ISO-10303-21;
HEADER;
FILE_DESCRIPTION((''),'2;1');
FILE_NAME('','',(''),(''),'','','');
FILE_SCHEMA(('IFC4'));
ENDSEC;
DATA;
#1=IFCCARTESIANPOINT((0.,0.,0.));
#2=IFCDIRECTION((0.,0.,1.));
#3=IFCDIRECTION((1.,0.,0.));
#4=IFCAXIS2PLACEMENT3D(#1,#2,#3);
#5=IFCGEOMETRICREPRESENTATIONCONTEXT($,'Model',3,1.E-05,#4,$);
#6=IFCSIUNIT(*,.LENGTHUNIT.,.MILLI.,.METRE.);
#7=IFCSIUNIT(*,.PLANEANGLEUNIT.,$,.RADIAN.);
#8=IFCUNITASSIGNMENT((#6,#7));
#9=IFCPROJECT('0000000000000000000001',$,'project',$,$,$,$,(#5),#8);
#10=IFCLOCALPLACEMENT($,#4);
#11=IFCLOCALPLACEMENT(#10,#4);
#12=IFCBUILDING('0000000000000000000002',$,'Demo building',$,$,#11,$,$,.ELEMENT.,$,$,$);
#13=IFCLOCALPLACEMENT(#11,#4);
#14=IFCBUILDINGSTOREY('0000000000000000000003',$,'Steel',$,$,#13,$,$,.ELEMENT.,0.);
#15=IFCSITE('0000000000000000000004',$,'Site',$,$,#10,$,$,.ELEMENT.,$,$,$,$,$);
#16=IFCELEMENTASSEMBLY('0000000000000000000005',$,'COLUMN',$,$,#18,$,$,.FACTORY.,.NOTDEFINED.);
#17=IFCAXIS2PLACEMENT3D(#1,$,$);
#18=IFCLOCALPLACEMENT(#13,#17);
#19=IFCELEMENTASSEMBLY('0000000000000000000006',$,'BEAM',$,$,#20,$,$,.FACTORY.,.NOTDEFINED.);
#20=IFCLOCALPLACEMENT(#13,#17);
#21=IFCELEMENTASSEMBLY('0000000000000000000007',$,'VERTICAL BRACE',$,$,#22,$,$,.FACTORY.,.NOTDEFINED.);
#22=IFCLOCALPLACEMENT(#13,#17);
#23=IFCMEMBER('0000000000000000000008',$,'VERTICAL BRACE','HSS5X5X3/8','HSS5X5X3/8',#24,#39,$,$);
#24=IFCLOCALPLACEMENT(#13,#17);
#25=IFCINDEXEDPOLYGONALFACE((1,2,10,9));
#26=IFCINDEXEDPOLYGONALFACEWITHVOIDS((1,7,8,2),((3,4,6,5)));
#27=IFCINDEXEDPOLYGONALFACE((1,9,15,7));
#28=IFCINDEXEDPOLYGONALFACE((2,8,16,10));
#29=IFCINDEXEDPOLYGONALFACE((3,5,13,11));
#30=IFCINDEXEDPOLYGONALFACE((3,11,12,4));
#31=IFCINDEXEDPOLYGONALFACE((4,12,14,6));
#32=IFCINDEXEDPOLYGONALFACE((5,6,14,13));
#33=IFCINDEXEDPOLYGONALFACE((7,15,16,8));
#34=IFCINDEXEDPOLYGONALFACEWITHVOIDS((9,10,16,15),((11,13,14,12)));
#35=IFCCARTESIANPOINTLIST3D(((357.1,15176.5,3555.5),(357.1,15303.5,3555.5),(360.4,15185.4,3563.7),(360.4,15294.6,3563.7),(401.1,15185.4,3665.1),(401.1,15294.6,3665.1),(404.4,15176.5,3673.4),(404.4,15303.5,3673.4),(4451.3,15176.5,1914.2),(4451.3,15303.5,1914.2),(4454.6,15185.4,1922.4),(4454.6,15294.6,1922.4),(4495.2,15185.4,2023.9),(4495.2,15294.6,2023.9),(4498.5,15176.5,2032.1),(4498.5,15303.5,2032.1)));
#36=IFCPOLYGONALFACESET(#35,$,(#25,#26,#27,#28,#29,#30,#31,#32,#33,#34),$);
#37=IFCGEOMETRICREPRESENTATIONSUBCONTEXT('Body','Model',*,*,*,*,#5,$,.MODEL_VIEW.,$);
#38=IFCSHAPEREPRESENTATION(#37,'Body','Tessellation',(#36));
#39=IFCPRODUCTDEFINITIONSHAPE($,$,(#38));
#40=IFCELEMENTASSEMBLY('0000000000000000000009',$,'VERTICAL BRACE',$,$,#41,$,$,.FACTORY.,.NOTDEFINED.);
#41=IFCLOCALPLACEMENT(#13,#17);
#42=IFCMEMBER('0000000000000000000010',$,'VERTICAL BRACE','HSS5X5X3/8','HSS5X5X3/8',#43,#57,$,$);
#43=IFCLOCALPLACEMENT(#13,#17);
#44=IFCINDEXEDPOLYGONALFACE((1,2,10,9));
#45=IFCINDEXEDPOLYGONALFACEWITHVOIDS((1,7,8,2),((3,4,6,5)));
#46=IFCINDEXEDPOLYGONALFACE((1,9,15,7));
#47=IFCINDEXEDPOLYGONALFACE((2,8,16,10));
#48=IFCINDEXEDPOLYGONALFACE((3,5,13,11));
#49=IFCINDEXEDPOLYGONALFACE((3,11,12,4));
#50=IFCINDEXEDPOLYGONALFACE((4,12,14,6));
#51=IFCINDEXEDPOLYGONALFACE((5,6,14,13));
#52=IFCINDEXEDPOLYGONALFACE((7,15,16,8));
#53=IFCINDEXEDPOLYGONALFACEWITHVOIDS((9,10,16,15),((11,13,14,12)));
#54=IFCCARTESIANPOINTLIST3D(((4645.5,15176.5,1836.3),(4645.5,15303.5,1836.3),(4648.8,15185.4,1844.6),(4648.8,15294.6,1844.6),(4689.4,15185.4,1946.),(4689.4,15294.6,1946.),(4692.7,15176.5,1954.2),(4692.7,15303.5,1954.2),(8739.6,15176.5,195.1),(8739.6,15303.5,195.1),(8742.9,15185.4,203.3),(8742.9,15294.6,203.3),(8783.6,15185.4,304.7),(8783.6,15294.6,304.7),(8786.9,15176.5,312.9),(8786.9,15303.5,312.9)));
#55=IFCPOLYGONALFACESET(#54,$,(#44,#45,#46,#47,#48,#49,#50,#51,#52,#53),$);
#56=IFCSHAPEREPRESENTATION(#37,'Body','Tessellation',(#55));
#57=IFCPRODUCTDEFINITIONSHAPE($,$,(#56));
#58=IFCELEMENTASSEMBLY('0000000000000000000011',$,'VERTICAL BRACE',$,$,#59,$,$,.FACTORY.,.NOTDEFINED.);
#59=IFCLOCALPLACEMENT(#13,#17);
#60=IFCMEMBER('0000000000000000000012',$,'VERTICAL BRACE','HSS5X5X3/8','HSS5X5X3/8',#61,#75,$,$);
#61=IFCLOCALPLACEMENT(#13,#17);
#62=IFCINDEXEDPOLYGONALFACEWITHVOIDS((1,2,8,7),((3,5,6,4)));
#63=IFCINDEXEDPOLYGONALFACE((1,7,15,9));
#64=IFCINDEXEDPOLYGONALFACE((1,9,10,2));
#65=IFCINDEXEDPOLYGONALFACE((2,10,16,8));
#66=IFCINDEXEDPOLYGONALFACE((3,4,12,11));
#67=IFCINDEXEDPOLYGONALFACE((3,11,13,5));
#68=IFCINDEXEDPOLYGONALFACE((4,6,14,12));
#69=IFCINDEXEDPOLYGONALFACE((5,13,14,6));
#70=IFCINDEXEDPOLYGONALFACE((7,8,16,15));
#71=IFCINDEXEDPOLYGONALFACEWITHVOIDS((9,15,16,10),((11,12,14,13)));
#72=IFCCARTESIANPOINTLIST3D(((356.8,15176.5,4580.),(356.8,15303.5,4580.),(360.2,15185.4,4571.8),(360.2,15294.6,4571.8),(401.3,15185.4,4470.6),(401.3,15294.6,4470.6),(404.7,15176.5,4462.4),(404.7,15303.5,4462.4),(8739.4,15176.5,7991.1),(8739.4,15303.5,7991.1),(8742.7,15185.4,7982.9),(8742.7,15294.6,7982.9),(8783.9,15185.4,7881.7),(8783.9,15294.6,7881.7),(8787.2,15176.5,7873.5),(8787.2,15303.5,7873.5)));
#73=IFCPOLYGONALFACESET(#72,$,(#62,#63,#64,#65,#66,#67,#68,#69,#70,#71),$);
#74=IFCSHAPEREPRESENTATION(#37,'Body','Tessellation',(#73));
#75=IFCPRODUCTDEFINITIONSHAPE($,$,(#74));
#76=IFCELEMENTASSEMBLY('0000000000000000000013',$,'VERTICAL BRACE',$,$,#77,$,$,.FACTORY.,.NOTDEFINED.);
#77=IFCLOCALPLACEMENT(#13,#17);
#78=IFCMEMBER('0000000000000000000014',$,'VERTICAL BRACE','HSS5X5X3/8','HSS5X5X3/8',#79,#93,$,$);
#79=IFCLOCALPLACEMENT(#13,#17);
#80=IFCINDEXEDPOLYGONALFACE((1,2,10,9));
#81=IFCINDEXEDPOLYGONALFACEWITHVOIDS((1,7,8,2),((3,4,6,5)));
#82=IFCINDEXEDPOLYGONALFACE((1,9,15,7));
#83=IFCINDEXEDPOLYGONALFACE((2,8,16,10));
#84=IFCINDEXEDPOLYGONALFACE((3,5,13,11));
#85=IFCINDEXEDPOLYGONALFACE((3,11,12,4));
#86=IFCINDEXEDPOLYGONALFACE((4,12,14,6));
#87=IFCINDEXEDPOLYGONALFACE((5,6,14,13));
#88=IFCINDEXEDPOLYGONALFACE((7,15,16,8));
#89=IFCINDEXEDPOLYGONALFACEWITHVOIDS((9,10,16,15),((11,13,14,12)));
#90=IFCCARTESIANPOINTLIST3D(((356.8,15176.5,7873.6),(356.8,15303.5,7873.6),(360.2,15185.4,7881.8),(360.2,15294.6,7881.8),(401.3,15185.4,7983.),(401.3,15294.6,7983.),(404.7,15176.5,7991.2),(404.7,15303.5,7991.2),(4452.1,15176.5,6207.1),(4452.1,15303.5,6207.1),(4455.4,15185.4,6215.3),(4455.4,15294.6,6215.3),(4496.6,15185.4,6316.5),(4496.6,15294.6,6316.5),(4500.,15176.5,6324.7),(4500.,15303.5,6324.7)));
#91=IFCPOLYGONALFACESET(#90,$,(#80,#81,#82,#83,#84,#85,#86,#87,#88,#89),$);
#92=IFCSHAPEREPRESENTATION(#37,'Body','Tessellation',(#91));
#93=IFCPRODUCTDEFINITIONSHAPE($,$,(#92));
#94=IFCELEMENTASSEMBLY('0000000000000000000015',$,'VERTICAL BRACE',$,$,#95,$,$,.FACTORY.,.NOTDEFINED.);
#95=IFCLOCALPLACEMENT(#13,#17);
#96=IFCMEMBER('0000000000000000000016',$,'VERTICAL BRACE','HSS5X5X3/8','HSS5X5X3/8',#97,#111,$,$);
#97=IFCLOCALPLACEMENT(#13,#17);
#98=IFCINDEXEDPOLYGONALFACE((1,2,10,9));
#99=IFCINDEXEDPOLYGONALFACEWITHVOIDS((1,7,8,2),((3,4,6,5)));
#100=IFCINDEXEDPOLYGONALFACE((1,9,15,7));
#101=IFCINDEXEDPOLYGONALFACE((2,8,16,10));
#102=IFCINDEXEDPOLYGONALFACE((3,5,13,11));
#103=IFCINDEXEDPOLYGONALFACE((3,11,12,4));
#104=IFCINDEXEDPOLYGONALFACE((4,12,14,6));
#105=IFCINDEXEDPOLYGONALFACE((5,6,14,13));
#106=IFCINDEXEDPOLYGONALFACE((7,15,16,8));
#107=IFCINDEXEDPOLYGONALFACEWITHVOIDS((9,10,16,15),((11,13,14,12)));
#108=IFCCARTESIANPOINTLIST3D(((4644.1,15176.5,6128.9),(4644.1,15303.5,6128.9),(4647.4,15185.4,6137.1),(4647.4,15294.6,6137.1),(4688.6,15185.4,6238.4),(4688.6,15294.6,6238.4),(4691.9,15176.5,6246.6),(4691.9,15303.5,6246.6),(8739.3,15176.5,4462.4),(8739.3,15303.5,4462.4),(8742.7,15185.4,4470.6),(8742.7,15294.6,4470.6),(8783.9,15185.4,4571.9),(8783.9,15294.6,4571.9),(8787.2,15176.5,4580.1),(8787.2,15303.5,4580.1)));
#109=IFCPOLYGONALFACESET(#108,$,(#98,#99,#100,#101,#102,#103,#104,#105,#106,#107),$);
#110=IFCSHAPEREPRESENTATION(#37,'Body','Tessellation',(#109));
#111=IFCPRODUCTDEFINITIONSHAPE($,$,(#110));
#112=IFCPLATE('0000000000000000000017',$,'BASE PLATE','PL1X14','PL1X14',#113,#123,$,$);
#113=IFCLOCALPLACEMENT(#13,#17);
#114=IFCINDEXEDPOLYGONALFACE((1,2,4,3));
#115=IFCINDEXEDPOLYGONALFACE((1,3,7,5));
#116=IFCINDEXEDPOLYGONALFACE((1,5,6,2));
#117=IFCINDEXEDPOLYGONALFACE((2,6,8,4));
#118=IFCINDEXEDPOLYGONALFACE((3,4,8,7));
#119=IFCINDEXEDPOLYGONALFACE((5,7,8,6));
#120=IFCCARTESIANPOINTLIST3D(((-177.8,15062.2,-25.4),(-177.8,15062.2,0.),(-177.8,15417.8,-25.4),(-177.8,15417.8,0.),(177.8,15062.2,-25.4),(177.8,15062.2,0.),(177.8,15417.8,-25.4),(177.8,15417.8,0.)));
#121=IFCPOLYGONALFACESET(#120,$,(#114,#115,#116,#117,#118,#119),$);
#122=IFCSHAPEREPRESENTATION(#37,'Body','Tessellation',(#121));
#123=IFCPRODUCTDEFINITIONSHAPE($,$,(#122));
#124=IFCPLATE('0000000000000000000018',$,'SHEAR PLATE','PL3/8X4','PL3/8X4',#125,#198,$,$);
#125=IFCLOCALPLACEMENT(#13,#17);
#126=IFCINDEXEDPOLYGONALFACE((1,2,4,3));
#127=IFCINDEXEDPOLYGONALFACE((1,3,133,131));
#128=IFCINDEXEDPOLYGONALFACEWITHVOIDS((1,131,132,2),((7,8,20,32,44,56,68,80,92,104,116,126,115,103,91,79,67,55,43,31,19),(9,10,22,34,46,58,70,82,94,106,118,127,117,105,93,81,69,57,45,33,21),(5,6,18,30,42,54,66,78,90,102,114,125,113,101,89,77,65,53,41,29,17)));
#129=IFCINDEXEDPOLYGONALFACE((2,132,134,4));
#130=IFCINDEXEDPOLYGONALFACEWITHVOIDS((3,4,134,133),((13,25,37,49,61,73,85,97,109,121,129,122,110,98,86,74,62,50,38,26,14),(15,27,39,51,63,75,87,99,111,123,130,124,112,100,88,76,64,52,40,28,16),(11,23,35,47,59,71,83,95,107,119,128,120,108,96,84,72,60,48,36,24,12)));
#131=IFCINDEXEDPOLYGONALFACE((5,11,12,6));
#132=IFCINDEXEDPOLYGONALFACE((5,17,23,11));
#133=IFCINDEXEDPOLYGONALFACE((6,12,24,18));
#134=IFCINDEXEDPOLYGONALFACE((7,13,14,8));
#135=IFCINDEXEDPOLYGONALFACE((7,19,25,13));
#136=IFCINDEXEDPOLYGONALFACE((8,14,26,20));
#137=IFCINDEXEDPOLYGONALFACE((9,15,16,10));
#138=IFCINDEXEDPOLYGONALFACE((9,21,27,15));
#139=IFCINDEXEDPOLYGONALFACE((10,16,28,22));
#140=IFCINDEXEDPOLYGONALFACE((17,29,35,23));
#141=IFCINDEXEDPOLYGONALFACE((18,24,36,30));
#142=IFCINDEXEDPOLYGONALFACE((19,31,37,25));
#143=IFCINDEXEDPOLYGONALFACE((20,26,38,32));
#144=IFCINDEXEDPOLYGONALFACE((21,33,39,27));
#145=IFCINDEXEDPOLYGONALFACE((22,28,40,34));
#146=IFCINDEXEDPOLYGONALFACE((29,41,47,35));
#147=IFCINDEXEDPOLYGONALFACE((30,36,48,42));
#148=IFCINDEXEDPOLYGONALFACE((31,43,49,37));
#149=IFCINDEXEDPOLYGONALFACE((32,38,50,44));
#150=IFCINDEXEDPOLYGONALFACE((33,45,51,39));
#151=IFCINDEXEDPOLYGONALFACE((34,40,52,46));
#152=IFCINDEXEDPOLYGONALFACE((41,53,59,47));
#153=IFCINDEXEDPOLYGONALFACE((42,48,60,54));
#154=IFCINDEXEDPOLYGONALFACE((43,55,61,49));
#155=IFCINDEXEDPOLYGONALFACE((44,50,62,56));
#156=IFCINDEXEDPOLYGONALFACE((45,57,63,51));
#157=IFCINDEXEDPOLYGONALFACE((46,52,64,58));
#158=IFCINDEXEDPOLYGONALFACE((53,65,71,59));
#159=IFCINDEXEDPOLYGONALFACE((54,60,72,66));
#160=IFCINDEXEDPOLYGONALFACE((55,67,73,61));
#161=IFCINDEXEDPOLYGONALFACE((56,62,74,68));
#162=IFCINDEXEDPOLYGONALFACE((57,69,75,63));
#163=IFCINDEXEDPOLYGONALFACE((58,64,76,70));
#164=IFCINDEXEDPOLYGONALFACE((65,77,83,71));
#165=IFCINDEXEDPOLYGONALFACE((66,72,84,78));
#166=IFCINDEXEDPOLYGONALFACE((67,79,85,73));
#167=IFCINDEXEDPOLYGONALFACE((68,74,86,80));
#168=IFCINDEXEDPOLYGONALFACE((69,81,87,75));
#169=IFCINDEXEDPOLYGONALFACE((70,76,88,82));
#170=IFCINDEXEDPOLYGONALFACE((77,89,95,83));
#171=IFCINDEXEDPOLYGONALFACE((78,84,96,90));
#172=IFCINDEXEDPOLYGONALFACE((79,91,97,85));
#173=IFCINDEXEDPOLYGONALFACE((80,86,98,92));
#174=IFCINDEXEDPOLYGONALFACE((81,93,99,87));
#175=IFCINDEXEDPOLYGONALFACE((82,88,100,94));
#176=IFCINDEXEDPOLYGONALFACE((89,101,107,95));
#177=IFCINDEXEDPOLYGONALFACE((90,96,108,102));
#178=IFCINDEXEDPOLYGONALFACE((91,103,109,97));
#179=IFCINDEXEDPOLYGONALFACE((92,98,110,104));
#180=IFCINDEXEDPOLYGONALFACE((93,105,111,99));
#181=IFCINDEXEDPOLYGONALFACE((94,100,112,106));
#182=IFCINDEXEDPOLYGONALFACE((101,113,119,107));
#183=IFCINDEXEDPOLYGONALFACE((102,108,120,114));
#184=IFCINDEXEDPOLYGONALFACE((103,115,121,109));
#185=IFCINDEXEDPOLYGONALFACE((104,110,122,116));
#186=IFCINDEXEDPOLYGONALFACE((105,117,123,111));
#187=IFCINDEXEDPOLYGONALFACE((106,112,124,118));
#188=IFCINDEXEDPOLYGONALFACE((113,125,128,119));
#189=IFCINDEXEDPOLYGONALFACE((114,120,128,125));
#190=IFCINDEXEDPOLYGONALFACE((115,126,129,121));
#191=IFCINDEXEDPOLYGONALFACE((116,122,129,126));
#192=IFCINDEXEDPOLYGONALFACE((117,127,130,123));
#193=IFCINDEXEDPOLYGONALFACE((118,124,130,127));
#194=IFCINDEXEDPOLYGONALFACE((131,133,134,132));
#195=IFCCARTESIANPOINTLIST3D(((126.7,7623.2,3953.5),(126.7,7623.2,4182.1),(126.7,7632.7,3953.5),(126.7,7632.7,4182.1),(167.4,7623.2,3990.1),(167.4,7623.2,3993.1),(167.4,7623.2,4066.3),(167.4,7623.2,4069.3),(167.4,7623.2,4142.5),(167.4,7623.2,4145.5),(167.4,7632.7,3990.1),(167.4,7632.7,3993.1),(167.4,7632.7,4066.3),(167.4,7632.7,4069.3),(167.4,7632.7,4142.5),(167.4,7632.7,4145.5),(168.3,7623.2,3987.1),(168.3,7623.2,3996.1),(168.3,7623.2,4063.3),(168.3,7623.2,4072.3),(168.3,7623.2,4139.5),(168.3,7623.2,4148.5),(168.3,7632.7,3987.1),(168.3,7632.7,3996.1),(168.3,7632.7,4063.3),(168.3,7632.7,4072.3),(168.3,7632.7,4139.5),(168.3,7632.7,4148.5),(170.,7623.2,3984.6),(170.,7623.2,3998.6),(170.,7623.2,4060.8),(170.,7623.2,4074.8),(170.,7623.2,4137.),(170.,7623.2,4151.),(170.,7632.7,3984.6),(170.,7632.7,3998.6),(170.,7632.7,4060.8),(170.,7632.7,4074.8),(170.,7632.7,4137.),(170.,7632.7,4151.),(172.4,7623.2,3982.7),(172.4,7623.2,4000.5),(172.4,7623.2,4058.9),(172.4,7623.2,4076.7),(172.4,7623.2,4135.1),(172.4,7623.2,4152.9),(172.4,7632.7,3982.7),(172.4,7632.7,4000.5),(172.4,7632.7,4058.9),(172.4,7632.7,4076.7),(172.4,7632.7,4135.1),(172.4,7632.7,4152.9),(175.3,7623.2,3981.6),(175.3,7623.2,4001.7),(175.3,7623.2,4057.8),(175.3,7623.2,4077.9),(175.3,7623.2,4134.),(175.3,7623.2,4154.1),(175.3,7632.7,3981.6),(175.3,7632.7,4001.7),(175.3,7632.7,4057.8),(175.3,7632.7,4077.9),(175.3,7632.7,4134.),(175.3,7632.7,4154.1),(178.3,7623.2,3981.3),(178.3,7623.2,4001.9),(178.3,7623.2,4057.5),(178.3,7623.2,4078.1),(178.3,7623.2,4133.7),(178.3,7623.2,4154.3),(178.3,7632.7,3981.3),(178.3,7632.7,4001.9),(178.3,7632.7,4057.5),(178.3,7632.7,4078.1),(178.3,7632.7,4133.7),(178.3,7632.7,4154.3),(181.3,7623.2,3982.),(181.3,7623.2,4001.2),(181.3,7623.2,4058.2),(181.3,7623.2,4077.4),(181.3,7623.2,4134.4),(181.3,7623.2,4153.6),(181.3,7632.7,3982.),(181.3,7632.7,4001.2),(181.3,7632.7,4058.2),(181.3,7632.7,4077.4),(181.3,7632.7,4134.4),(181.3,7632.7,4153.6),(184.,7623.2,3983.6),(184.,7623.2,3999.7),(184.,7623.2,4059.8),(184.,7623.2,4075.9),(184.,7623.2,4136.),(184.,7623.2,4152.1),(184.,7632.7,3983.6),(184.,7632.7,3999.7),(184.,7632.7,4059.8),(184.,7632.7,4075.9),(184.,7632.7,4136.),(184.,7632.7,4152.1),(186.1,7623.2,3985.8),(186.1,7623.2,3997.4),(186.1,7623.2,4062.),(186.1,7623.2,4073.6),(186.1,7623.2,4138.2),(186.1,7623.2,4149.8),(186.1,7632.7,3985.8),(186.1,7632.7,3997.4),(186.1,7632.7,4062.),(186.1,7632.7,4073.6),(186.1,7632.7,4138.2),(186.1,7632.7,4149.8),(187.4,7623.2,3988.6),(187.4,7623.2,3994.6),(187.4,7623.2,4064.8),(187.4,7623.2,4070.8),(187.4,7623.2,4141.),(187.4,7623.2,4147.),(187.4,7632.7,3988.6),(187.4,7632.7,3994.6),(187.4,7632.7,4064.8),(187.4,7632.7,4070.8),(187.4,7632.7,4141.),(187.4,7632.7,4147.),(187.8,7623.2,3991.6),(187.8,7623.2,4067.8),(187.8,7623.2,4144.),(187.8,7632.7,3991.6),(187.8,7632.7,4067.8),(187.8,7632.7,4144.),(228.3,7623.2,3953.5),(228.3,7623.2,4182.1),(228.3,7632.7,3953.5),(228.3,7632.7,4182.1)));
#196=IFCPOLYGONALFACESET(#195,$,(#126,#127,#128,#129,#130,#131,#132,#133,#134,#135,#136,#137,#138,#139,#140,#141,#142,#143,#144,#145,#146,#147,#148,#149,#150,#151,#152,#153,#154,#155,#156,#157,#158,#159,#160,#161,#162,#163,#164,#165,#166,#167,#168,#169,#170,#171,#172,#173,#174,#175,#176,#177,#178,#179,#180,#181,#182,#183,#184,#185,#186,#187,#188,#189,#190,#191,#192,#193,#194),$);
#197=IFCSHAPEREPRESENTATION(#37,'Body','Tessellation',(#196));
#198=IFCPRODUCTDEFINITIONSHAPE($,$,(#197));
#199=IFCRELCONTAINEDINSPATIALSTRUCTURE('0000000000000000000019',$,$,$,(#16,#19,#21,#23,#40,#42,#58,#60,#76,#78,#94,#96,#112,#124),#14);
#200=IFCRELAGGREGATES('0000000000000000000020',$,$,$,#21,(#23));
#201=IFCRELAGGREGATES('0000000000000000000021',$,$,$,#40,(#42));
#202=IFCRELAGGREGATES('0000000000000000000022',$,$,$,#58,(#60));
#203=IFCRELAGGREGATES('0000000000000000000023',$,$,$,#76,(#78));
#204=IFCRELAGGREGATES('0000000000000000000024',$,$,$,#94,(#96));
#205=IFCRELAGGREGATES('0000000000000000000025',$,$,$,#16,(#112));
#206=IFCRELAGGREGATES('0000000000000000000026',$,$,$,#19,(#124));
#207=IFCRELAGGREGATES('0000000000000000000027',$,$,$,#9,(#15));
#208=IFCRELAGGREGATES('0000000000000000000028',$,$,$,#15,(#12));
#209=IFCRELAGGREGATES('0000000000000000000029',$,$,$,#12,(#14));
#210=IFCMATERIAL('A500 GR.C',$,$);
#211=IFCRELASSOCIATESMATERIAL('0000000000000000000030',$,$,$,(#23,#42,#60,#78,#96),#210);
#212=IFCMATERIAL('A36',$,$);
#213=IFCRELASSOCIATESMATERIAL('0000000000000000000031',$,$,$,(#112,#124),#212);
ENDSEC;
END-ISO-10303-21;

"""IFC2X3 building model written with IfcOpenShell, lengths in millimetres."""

from ifc_helpers import new_model, si_unit, frame, frame_2d, origin, origin_with_axes, origin_2d, place, context, subcontext, project, spatial, rectangle, hollow_rectangle, circle, extrude, boolean, material, element, aggregate, save


model = new_model("IFC2X3")

# Units and contexts
model_context = context("Model", 3, precision=1e-05, world=origin_with_axes())
body_context = subcontext(model_context, "Body", "Model", "MODEL_VIEW")
ifc_project = project(units=[si_unit("LENGTHUNIT", "METRE", prefix="MILLI"), si_unit("PLANEANGLEUNIT", "RADIAN")], contexts=[model_context])

# Site, building, storey
site_placement = place(None, origin_with_axes())
site = spatial("IfcSite", under=ifc_project, at=site_placement, Name="Site", CompositionType="ELEMENT")
building_placement = place(site_placement, origin_with_axes())
building = spatial("IfcBuilding", under=site, at=building_placement, Name="Demo building", CompositionType="ELEMENT")
placement = place(building_placement, origin_with_axes())
storey = spatial("IfcBuildingStorey", under=building, at=placement, Name="Steel", CompositionType="ELEMENT", Elevation=0.0)

# Element assembly
assembly_1 = element("IfcElementAssembly", 1, at=placement, inside=storey, Name="COLUMN", AssemblyPlace="FACTORY", PredefinedType="NOTDEFINED")

# Element assembly
assembly_2 = element("IfcElementAssembly", 2, at=placement, inside=storey, Name="BEAM", AssemblyPlace="FACTORY", PredefinedType="NOTDEFINED")

# Element assemblies, members
ifc_material_1 = material(Name="A500 GR.C")
assembly_3 = element("IfcElementAssembly", 3, at=placement, inside=storey, Name="VERTICAL BRACE", AssemblyPlace="FACTORY", PredefinedType="NOTDEFINED")
member_1_placement = place(placement, frame((380.7, 15240.0, 3614.4), z_axis=(0.9282, 0.0, -0.3721), x_axis=(0.0, 1.0, 0.0)))
member_1 = element("IfcMember", 4, at=member_1_placement, inside=storey, material=ifc_material_1, Name="VERTICAL BRACE", Description="HSS5X5X3/8", ObjectType="HSS5X5X3/8", context=body_context, shape_type="SweptSolid", body=[
    extrude(hollow_rectangle(XDim=127.0, YDim=127.0, WallThickness=8.9, at=origin_2d()), origin(), (0.0, 0.0, 1.0), 4410.9),
])
aggregate(assembly_3, [member_1])
assembly_4 = element("IfcElementAssembly", 5, at=placement, inside=storey, Name="VERTICAL BRACE", AssemblyPlace="FACTORY", PredefinedType="NOTDEFINED")
member_2_placement = place(placement, frame((4669.1, 15240.0, 1895.3), z_axis=(0.9282, 0.0, -0.3721), x_axis=(0.0, 1.0, 0.0)))
member_2 = element("IfcMember", 6, at=member_2_placement, inside=storey, material=ifc_material_1, Name="VERTICAL BRACE", Description="HSS5X5X3/8", ObjectType="HSS5X5X3/8", context=body_context, shape_type="SweptSolid", body=[
    extrude(hollow_rectangle(XDim=127.0, YDim=127.0, WallThickness=8.9, at=origin_2d()), origin(), (0.0, 0.0, 1.0), 4410.9),
])
aggregate(assembly_4, [member_2])
assembly_5 = element("IfcElementAssembly", 7, at=placement, inside=storey, Name="VERTICAL BRACE", AssemblyPlace="FACTORY", PredefinedType="NOTDEFINED")
member_3_placement = place(placement, frame((380.7, 15240.0, 4521.2), z_axis=(0.9262, 0.0, 0.3769), x_axis=(0.0, 1.0, 0.0)))
member_3 = element("IfcMember", 8, at=member_3_placement, inside=storey, material=ifc_material_1, Name="VERTICAL BRACE", Description="HSS5X5X3/8", ObjectType="HSS5X5X3/8", context=body_context, shape_type="SweptSolid", body=[
    extrude(hollow_rectangle(XDim=127.0, YDim=127.0, WallThickness=8.9, at=origin_2d()), origin(), (0.0, 0.0, 1.0), 9050.0),
])
aggregate(assembly_5, [member_3])
assembly_6 = element("IfcElementAssembly", 9, at=placement, inside=storey, Name="VERTICAL BRACE", AssemblyPlace="FACTORY", PredefinedType="NOTDEFINED")
member_4_placement = place(placement, frame((380.7, 15240.0, 7932.4), z_axis=(0.9262, 0.0, -0.3769), x_axis=(0.0, 1.0, 0.0)))
member_4 = element("IfcMember", 10, at=member_4_placement, inside=storey, material=ifc_material_1, Name="VERTICAL BRACE", Description="HSS5X5X3/8", ObjectType="HSS5X5X3/8", context=body_context, shape_type="SweptSolid", body=[
    extrude(hollow_rectangle(XDim=127.0, YDim=127.0, WallThickness=8.9, at=origin_2d()), origin(), (0.0, 0.0, 1.0), 4421.4),
])
aggregate(assembly_6, [member_4])
assembly_7 = element("IfcElementAssembly", 11, at=placement, inside=storey, Name="VERTICAL BRACE", AssemblyPlace="FACTORY", PredefinedType="NOTDEFINED")
member_5_placement = place(placement, frame((4668.0, 15240.0, 6187.7), z_axis=(0.9262, 0.0, -0.3769), x_axis=(0.0, 1.0, 0.0)))
member_5 = element("IfcMember", 12, at=member_5_placement, inside=storey, material=ifc_material_1, Name="VERTICAL BRACE", Description="HSS5X5X3/8", ObjectType="HSS5X5X3/8", context=body_context, shape_type="SweptSolid", body=[
    extrude(hollow_rectangle(XDim=127.0, YDim=127.0, WallThickness=8.9, at=origin_2d()), origin(), (0.0, 0.0, 1.0), 4421.4),
])
aggregate(assembly_7, [member_5])

# Plates
ifc_material_2 = material(Name="A36")
plate_1_placement = place(placement, frame((-177.8, 15062.2, -25.4), z_axis=(0.0, 0.0, 1.0), x_axis=(1.0, 0.0, 0.0)))
plate_1 = element("IfcPlate", 13, at=plate_1_placement, inside=storey, material=ifc_material_2, Name="BASE PLATE", Description="PL1X14", ObjectType="PL1X14", context=body_context, shape_type="SweptSolid", body=[
    extrude(rectangle(XDim=355.6, YDim=355.6, at=frame_2d((177.8, 177.8))), origin(), (0.0, 0.0, 1.0), 25.4),
])
aggregate(assembly_1, [plate_1])
plate_2_placement = place(placement, frame((126.7, 7632.7, 3953.5), z_axis=(0.0, -1.0, 0.0), x_axis=(1.0, 0.0, 0.0)))
plate_2 = element("IfcPlate", 14, at=plate_2_placement, inside=storey, material=ifc_material_2, Name="SHEAR PLATE", Description="PL3/8X4", ObjectType="PL3/8X4", context=body_context, shape_type="CSG", body=[
    boolean("DIFFERENCE", boolean("DIFFERENCE", boolean("DIFFERENCE", extrude(rectangle(XDim=101.6, YDim=228.6, at=frame_2d((50.8, 114.3))), origin(), (0.0, 0.0, 1.0), 9.5), extrude(circle(Radius=10.3, at=frame_2d((50.8, 38.1))), frame((0.0, 0.0, -5.0)), (0.0, 0.0, 1.0), 19.5)), extrude(circle(Radius=10.3, at=frame_2d((50.8, 114.3))), frame((0.0, 0.0, -5.0)), (0.0, 0.0, 1.0), 19.5)), extrude(circle(Radius=10.3, at=frame_2d((50.8, 190.5))), frame((0.0, 0.0, -5.0)), (0.0, 0.0, 1.0), 19.5)),
])
aggregate(assembly_2, [plate_2])

save(model, "model.ifc")
